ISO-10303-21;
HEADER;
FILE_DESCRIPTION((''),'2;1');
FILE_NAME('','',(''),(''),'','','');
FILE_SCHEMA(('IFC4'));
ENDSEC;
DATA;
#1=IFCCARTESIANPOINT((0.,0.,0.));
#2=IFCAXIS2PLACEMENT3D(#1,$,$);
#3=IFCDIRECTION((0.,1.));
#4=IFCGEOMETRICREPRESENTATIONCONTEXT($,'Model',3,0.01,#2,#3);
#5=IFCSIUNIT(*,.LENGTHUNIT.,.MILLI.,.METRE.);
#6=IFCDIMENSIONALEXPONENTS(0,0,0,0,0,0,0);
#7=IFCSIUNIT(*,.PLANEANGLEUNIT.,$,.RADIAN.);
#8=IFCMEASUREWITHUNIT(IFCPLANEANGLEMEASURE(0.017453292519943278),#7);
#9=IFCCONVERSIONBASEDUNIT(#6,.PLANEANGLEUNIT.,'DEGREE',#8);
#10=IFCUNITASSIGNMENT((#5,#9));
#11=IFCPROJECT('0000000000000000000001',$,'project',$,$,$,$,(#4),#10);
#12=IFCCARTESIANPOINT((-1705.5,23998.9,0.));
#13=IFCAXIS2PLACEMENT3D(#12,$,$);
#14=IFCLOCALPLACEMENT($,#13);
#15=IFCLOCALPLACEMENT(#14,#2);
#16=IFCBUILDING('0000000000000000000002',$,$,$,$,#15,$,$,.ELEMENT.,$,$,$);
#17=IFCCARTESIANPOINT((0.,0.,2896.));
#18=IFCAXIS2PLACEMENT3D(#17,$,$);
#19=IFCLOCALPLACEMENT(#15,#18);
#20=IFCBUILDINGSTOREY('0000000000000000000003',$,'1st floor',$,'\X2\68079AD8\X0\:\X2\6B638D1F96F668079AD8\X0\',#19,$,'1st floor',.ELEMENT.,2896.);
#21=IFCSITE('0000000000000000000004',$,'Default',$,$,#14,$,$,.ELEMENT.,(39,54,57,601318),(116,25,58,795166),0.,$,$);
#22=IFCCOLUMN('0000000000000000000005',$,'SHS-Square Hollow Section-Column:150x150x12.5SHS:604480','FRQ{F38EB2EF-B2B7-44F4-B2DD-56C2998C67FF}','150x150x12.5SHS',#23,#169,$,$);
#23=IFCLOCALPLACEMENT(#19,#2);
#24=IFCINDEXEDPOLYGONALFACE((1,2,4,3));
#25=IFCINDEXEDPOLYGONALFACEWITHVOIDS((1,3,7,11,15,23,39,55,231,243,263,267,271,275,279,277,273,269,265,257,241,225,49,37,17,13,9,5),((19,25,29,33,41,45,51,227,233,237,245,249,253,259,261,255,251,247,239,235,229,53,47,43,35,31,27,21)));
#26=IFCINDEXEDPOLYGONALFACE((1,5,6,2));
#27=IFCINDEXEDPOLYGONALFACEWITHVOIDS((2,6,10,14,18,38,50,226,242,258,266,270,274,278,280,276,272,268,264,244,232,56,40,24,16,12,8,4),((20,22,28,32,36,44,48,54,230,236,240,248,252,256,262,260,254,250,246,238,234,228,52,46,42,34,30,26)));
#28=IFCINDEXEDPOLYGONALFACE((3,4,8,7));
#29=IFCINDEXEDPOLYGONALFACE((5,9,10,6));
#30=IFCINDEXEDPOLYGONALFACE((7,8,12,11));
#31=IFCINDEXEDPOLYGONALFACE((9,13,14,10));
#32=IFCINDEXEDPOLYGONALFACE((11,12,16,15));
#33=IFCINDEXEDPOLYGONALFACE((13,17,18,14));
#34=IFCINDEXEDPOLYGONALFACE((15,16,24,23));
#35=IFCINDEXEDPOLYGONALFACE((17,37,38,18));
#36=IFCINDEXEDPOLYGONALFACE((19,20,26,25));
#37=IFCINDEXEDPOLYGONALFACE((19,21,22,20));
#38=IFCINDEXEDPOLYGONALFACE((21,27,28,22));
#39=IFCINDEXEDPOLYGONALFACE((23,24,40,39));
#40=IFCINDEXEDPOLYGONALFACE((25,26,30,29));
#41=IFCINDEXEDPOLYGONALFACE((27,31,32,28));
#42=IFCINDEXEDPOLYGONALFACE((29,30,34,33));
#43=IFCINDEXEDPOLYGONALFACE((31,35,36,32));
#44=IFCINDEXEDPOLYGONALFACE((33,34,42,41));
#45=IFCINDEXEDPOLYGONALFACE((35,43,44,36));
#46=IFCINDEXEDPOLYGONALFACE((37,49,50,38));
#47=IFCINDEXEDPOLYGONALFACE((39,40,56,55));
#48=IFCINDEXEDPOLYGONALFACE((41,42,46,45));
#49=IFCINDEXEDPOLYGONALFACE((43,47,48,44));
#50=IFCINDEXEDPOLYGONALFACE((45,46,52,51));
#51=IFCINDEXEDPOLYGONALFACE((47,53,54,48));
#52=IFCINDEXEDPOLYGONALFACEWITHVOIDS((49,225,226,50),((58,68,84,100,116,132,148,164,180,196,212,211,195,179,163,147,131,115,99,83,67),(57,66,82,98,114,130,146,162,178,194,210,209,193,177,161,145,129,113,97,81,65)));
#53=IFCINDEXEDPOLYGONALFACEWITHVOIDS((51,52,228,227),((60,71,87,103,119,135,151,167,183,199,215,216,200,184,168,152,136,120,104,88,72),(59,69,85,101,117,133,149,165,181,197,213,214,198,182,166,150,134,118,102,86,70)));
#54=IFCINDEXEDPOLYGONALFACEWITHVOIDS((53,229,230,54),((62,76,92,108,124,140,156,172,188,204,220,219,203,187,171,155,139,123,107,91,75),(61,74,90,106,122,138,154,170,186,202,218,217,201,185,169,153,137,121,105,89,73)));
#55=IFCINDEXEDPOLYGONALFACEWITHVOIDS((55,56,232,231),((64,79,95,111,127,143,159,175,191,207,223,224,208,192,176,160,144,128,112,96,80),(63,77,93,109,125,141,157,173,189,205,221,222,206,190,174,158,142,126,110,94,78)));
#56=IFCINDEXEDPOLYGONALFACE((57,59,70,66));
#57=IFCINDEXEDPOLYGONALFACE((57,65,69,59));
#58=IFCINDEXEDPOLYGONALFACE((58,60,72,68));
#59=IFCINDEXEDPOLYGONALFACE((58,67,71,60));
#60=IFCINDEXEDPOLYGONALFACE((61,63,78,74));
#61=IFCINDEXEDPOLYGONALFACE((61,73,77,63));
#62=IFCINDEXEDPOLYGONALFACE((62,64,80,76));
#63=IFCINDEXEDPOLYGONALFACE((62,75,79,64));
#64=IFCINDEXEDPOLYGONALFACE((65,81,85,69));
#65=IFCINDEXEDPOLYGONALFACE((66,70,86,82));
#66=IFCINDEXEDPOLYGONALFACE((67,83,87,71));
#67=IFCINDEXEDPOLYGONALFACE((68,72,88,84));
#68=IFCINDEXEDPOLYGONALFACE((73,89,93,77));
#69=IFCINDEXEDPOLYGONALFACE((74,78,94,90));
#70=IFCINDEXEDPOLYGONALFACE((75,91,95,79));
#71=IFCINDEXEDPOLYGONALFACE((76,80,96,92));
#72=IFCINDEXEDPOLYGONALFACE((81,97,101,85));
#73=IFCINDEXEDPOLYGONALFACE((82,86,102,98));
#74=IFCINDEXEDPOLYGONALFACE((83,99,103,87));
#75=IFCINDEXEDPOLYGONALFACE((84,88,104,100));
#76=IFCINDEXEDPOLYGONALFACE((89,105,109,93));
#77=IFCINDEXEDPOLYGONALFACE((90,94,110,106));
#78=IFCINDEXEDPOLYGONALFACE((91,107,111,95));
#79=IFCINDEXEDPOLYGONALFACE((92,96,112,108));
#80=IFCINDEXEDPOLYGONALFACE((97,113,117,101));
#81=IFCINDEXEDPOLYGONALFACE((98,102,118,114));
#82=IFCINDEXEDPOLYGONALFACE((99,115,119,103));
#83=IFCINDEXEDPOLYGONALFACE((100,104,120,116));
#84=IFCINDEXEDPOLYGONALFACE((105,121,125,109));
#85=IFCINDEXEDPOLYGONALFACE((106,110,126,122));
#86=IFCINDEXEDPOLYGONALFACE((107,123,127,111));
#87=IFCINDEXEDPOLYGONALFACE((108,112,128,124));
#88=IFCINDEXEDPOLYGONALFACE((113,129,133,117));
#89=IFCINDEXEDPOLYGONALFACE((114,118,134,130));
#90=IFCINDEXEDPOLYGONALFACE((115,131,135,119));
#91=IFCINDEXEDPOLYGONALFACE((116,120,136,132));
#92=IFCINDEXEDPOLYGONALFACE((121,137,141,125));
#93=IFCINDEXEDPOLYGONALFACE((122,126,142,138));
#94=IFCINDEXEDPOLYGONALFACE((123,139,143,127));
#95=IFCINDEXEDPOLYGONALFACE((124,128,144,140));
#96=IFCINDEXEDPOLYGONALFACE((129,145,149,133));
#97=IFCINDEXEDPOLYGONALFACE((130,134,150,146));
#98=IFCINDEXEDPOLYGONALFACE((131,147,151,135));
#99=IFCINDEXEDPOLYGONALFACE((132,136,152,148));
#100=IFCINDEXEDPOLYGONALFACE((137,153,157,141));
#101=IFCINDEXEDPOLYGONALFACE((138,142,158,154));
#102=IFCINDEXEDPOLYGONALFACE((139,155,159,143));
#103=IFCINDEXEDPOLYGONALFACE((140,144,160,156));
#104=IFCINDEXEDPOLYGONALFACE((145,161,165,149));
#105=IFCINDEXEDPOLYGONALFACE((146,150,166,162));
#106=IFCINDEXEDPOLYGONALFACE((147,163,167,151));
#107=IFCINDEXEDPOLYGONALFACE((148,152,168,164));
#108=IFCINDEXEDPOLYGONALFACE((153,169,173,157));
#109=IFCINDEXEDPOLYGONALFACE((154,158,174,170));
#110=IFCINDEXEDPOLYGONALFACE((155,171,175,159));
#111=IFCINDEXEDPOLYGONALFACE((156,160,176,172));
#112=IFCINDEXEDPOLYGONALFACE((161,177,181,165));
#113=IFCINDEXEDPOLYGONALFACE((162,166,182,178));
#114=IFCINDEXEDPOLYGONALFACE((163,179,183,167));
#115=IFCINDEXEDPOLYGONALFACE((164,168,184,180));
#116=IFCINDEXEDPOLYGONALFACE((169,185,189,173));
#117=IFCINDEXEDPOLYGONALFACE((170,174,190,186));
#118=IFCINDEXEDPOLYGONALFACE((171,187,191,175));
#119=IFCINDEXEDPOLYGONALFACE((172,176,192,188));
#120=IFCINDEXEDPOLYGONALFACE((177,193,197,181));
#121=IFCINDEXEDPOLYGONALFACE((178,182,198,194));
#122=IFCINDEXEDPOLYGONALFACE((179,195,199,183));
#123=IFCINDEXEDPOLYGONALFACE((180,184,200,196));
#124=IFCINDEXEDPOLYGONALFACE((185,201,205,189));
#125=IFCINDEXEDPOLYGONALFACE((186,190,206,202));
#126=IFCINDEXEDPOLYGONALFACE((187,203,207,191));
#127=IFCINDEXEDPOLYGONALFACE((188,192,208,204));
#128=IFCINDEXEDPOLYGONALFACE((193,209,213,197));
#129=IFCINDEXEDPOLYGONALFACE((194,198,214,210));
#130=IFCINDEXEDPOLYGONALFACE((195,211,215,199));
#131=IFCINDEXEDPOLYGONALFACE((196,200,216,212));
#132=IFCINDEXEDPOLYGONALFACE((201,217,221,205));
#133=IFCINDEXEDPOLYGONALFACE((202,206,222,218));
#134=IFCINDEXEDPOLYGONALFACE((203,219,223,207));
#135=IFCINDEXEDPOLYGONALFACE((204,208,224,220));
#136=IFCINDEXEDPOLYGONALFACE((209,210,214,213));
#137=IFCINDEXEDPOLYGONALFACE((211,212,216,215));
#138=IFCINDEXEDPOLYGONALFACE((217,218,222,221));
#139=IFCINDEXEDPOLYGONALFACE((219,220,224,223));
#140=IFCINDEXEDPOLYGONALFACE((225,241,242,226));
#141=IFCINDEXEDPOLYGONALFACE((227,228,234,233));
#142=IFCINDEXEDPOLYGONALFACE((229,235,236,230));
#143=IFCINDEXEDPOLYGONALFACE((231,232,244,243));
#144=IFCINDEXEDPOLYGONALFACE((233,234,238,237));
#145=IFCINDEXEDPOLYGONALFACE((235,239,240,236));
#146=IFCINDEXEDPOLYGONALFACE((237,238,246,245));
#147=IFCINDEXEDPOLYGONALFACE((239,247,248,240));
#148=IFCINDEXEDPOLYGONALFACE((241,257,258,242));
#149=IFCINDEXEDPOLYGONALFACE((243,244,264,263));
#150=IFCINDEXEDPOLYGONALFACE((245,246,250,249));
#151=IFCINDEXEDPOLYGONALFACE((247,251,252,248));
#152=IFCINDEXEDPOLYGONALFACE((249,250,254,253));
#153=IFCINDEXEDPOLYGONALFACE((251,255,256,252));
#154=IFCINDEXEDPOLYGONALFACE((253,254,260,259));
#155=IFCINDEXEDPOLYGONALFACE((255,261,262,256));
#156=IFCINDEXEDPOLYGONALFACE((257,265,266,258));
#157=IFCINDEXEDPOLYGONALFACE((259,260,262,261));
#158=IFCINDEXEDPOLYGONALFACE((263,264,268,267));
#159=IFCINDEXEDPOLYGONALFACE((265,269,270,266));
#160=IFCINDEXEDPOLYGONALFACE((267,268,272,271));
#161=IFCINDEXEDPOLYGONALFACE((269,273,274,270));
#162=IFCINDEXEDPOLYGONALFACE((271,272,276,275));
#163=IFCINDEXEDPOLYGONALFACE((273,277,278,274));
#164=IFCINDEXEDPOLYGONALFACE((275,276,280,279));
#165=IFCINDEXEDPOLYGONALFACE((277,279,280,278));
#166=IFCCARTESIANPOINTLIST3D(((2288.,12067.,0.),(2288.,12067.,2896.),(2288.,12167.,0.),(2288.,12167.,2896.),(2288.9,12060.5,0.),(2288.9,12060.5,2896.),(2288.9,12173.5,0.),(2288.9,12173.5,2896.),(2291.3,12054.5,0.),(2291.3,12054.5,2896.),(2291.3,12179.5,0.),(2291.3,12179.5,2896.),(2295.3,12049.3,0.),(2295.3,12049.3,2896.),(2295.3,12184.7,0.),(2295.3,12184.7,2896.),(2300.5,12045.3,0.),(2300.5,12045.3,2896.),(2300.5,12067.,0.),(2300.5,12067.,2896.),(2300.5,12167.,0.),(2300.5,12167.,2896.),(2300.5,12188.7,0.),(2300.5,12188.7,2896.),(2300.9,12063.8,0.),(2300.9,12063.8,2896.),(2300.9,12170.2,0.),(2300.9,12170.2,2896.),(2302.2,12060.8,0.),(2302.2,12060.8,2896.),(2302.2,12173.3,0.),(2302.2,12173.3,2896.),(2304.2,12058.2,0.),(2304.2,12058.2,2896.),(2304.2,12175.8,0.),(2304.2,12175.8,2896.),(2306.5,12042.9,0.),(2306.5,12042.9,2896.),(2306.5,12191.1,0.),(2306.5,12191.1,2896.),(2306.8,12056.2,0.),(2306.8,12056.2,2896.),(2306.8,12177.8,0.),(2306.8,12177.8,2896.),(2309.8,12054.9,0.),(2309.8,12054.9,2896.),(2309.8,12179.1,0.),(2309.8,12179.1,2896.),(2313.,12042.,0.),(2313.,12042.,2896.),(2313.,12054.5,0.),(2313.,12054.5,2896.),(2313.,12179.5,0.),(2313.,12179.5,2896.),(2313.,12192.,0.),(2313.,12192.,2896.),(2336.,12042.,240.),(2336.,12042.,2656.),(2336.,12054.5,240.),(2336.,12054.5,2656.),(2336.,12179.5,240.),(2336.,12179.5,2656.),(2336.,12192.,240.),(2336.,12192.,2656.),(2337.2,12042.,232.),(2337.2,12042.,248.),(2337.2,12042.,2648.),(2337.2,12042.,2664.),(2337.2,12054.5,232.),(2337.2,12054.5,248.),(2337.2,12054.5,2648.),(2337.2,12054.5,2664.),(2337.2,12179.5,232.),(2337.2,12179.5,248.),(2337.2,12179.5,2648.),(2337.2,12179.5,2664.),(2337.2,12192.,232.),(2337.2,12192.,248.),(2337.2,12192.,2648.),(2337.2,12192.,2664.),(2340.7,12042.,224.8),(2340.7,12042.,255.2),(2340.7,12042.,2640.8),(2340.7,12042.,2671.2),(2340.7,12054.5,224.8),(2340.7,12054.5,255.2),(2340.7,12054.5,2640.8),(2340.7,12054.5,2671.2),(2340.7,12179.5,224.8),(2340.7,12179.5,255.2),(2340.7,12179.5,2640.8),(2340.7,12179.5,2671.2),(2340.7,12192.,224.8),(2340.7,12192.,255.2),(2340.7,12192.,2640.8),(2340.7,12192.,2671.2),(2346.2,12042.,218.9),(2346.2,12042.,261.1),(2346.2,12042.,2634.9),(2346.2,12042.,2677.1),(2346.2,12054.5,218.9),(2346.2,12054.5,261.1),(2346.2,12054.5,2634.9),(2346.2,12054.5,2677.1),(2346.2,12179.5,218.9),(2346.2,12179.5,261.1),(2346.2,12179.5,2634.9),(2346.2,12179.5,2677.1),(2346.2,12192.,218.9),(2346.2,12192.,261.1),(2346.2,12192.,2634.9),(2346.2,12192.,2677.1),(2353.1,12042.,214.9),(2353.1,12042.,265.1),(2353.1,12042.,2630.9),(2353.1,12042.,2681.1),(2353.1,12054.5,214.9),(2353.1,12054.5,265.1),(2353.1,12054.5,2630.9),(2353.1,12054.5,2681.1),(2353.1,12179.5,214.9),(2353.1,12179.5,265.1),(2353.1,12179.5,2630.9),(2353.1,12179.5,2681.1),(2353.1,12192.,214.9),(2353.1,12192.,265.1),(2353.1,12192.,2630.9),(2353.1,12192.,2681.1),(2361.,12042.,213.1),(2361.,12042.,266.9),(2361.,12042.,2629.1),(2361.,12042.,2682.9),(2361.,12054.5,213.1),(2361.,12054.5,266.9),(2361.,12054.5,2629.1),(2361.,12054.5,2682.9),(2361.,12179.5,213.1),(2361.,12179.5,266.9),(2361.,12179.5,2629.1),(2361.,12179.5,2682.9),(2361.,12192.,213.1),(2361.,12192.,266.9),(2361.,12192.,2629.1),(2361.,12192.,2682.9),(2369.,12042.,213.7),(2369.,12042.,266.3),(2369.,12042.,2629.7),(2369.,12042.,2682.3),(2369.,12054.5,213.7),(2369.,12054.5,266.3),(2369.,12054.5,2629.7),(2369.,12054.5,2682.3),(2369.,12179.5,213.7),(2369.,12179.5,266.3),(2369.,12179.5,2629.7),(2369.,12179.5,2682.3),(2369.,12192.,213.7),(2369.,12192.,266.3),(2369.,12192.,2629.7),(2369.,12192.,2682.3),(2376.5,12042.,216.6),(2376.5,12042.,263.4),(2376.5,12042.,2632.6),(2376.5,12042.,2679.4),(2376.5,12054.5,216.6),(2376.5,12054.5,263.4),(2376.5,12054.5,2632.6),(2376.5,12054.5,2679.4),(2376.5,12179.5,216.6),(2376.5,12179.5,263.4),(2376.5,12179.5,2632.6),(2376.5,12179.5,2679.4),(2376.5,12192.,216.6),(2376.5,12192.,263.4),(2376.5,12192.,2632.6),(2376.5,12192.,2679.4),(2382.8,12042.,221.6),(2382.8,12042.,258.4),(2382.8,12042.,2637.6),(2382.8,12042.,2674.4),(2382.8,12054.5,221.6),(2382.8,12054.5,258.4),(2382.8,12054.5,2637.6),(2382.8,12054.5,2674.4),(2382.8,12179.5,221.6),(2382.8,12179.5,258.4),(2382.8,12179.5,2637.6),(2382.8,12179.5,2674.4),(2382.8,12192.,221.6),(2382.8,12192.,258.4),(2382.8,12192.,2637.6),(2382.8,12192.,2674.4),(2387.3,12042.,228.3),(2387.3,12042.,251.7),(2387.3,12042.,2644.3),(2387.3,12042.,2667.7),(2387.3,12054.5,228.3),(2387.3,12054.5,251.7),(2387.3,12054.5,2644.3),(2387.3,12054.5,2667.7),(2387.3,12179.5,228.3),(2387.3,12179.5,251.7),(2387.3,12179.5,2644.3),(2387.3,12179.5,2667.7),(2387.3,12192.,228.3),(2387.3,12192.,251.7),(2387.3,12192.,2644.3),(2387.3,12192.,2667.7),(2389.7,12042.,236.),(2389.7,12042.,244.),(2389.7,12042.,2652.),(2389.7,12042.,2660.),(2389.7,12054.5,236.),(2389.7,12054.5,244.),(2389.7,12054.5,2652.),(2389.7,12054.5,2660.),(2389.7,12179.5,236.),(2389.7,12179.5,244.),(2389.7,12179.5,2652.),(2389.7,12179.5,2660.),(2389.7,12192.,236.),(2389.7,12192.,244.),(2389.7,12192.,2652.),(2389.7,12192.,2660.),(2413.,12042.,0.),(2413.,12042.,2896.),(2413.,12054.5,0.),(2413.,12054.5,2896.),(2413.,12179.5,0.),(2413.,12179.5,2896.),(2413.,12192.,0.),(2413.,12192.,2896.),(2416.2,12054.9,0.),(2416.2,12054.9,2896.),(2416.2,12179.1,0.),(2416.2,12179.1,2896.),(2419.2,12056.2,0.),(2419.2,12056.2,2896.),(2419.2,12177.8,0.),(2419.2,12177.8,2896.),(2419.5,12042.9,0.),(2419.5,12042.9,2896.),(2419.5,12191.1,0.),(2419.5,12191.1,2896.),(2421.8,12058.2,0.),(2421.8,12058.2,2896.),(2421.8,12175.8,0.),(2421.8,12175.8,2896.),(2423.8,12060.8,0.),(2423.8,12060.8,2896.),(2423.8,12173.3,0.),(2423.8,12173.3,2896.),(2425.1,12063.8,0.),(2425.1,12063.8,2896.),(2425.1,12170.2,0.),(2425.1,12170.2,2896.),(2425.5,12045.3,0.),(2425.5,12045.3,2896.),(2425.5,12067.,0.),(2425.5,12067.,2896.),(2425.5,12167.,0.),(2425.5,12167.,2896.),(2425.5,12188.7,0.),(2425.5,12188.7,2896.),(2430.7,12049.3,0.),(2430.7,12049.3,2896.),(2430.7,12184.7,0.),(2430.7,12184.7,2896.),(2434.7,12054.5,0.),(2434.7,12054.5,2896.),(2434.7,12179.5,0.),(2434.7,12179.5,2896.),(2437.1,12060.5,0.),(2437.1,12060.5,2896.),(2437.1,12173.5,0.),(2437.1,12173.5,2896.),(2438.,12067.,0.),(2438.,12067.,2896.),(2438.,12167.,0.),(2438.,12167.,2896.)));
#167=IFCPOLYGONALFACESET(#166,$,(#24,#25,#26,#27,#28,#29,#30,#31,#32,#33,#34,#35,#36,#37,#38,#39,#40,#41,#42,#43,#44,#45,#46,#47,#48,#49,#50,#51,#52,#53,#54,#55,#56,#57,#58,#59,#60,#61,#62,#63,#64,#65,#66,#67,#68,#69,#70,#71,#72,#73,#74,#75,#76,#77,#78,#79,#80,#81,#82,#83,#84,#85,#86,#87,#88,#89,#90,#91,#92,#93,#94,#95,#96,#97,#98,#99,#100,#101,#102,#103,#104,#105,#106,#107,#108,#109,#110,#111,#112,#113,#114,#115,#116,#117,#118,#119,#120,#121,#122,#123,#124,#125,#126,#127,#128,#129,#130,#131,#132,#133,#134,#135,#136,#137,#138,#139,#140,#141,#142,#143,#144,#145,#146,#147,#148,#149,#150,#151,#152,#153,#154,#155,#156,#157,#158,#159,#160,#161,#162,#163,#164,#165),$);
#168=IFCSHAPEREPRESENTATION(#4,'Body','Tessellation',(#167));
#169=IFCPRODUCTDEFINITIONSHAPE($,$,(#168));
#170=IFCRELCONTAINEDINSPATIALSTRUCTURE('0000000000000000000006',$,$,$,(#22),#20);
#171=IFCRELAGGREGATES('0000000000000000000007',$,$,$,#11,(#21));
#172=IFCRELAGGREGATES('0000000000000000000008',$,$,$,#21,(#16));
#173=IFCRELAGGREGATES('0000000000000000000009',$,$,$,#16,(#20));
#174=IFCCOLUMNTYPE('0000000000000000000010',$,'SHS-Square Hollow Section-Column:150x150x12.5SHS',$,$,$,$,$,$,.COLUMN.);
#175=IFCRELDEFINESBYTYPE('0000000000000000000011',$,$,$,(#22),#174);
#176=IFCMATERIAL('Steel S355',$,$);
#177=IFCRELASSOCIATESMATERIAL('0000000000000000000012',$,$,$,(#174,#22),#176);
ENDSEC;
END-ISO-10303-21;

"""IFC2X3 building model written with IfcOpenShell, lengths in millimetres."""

from ifc_helpers import new_model, entity, si_unit, converted_unit, direction, frame, frame_2d, origin, origin_2d, place, context, project, spatial, circle_curve, hollow_rectangle, outline, extrude, material, type_object, element, save


model = new_model("IFC2X3")

# Units and contexts
model_context = context("Model", 3, precision=0.01, world=origin(), true_north=direction((0.0, 1.0)))
ifc_project = project(units=[si_unit("LENGTHUNIT", "METRE", prefix="MILLI"), converted_unit("PLANEANGLEUNIT", "DEGREE", entity("IfcPlaneAngleMeasure", 0.017453292519943278), si_unit("PLANEANGLEUNIT", "RADIAN"), dimensions=[0, 0, 0, 0, 0, 0, 0])], contexts=[model_context])

# Site, building, storey
site_placement = place(None, frame((-1705.5, 23998.9, 0.0)))
site = spatial("IfcSite", under=ifc_project, at=site_placement, Name="Default", CompositionType="ELEMENT", RefLatitude=(39, 54, 57, 601318), RefLongitude=(116, 25, 58, 795166), RefElevation=0.0)
building_placement = place(site_placement, origin())
building = spatial("IfcBuilding", under=site, at=building_placement, CompositionType="ELEMENT")
storey_placement = place(building_placement, frame((0.0, 0.0, 2896.0)))
storey = spatial("IfcBuildingStorey", under=building, at=storey_placement, Name="1st floor", ObjectType="标高:正负零标高", LongName="1st floor", CompositionType="ELEMENT", Elevation=2896.0)

# Shared definitions
ifc_material_1 = material(Name="Steel S355")

# Column, openings
column_type_1 = type_object("IfcColumnType", Name="SHS-Square Hollow Section-Column:150x150x12.5SHS", PredefinedType="COLUMN", material=ifc_material_1)
column_1_placement = place(storey_placement, frame((2363.0, 12117.0, 2896.0), z_axis=(0.0, 0.0, 1.0), x_axis=(0.0, -1.0, 0.0)))
column_1 = element("IfcColumn", 1, at=column_1_placement, inside=storey, type_object=column_type_1, material=ifc_material_1, Name="SHS-Square Hollow Section-Column:150x150x12.5SHS:604480", Description="FRQ{F38EB2EF-B2B7-44F4-B2DD-56C2998C67FF}", ObjectType="150x150x12.5SHS", context=model_context, shape_type="SweptSolid", body=[
    extrude(hollow_rectangle(XDim=150.0, YDim=150.0, WallThickness=12.5, InnerFilletRadius=12.5, OuterFilletRadius=25.0, at=origin_2d()), origin(), (0.0, 0.0, -1.0), 2896.0),
])
opening_1_placement = place(column_1_placement, frame((175.1, 0.0, 0.0), z_axis=(-1.0, 0.0, 0.0), x_axis=(0.0, -1.0, 0.0)))
element("IfcOpeningElement", 2, at=opening_1_placement, cuts=column_1, ObjectType="Opening", context=model_context, shape_type="SweptSolid", body=[
    extrude(outline(circle_curve(frame_2d((0.0, -240.0), x_axis=(1.0, 0.0)), 27.0)), origin(), (0.0, 0.0, 1.0), 350.2),
])
opening_2_placement = place(column_1_placement, frame((175.1, 0.0, -2896.0), z_axis=(-1.0, 0.0, 0.0), x_axis=(0.0, -1.0, 0.0)))
element("IfcOpeningElement", 3, at=opening_2_placement, cuts=column_1, ObjectType="Opening", context=model_context, shape_type="SweptSolid", body=[
    extrude(outline(circle_curve(frame_2d((0.0, 240.0), x_axis=(1.0, 0.0)), 27.0)), origin(), (0.0, 0.0, 1.0), 350.2),
])

save(model, "model.ifc")
